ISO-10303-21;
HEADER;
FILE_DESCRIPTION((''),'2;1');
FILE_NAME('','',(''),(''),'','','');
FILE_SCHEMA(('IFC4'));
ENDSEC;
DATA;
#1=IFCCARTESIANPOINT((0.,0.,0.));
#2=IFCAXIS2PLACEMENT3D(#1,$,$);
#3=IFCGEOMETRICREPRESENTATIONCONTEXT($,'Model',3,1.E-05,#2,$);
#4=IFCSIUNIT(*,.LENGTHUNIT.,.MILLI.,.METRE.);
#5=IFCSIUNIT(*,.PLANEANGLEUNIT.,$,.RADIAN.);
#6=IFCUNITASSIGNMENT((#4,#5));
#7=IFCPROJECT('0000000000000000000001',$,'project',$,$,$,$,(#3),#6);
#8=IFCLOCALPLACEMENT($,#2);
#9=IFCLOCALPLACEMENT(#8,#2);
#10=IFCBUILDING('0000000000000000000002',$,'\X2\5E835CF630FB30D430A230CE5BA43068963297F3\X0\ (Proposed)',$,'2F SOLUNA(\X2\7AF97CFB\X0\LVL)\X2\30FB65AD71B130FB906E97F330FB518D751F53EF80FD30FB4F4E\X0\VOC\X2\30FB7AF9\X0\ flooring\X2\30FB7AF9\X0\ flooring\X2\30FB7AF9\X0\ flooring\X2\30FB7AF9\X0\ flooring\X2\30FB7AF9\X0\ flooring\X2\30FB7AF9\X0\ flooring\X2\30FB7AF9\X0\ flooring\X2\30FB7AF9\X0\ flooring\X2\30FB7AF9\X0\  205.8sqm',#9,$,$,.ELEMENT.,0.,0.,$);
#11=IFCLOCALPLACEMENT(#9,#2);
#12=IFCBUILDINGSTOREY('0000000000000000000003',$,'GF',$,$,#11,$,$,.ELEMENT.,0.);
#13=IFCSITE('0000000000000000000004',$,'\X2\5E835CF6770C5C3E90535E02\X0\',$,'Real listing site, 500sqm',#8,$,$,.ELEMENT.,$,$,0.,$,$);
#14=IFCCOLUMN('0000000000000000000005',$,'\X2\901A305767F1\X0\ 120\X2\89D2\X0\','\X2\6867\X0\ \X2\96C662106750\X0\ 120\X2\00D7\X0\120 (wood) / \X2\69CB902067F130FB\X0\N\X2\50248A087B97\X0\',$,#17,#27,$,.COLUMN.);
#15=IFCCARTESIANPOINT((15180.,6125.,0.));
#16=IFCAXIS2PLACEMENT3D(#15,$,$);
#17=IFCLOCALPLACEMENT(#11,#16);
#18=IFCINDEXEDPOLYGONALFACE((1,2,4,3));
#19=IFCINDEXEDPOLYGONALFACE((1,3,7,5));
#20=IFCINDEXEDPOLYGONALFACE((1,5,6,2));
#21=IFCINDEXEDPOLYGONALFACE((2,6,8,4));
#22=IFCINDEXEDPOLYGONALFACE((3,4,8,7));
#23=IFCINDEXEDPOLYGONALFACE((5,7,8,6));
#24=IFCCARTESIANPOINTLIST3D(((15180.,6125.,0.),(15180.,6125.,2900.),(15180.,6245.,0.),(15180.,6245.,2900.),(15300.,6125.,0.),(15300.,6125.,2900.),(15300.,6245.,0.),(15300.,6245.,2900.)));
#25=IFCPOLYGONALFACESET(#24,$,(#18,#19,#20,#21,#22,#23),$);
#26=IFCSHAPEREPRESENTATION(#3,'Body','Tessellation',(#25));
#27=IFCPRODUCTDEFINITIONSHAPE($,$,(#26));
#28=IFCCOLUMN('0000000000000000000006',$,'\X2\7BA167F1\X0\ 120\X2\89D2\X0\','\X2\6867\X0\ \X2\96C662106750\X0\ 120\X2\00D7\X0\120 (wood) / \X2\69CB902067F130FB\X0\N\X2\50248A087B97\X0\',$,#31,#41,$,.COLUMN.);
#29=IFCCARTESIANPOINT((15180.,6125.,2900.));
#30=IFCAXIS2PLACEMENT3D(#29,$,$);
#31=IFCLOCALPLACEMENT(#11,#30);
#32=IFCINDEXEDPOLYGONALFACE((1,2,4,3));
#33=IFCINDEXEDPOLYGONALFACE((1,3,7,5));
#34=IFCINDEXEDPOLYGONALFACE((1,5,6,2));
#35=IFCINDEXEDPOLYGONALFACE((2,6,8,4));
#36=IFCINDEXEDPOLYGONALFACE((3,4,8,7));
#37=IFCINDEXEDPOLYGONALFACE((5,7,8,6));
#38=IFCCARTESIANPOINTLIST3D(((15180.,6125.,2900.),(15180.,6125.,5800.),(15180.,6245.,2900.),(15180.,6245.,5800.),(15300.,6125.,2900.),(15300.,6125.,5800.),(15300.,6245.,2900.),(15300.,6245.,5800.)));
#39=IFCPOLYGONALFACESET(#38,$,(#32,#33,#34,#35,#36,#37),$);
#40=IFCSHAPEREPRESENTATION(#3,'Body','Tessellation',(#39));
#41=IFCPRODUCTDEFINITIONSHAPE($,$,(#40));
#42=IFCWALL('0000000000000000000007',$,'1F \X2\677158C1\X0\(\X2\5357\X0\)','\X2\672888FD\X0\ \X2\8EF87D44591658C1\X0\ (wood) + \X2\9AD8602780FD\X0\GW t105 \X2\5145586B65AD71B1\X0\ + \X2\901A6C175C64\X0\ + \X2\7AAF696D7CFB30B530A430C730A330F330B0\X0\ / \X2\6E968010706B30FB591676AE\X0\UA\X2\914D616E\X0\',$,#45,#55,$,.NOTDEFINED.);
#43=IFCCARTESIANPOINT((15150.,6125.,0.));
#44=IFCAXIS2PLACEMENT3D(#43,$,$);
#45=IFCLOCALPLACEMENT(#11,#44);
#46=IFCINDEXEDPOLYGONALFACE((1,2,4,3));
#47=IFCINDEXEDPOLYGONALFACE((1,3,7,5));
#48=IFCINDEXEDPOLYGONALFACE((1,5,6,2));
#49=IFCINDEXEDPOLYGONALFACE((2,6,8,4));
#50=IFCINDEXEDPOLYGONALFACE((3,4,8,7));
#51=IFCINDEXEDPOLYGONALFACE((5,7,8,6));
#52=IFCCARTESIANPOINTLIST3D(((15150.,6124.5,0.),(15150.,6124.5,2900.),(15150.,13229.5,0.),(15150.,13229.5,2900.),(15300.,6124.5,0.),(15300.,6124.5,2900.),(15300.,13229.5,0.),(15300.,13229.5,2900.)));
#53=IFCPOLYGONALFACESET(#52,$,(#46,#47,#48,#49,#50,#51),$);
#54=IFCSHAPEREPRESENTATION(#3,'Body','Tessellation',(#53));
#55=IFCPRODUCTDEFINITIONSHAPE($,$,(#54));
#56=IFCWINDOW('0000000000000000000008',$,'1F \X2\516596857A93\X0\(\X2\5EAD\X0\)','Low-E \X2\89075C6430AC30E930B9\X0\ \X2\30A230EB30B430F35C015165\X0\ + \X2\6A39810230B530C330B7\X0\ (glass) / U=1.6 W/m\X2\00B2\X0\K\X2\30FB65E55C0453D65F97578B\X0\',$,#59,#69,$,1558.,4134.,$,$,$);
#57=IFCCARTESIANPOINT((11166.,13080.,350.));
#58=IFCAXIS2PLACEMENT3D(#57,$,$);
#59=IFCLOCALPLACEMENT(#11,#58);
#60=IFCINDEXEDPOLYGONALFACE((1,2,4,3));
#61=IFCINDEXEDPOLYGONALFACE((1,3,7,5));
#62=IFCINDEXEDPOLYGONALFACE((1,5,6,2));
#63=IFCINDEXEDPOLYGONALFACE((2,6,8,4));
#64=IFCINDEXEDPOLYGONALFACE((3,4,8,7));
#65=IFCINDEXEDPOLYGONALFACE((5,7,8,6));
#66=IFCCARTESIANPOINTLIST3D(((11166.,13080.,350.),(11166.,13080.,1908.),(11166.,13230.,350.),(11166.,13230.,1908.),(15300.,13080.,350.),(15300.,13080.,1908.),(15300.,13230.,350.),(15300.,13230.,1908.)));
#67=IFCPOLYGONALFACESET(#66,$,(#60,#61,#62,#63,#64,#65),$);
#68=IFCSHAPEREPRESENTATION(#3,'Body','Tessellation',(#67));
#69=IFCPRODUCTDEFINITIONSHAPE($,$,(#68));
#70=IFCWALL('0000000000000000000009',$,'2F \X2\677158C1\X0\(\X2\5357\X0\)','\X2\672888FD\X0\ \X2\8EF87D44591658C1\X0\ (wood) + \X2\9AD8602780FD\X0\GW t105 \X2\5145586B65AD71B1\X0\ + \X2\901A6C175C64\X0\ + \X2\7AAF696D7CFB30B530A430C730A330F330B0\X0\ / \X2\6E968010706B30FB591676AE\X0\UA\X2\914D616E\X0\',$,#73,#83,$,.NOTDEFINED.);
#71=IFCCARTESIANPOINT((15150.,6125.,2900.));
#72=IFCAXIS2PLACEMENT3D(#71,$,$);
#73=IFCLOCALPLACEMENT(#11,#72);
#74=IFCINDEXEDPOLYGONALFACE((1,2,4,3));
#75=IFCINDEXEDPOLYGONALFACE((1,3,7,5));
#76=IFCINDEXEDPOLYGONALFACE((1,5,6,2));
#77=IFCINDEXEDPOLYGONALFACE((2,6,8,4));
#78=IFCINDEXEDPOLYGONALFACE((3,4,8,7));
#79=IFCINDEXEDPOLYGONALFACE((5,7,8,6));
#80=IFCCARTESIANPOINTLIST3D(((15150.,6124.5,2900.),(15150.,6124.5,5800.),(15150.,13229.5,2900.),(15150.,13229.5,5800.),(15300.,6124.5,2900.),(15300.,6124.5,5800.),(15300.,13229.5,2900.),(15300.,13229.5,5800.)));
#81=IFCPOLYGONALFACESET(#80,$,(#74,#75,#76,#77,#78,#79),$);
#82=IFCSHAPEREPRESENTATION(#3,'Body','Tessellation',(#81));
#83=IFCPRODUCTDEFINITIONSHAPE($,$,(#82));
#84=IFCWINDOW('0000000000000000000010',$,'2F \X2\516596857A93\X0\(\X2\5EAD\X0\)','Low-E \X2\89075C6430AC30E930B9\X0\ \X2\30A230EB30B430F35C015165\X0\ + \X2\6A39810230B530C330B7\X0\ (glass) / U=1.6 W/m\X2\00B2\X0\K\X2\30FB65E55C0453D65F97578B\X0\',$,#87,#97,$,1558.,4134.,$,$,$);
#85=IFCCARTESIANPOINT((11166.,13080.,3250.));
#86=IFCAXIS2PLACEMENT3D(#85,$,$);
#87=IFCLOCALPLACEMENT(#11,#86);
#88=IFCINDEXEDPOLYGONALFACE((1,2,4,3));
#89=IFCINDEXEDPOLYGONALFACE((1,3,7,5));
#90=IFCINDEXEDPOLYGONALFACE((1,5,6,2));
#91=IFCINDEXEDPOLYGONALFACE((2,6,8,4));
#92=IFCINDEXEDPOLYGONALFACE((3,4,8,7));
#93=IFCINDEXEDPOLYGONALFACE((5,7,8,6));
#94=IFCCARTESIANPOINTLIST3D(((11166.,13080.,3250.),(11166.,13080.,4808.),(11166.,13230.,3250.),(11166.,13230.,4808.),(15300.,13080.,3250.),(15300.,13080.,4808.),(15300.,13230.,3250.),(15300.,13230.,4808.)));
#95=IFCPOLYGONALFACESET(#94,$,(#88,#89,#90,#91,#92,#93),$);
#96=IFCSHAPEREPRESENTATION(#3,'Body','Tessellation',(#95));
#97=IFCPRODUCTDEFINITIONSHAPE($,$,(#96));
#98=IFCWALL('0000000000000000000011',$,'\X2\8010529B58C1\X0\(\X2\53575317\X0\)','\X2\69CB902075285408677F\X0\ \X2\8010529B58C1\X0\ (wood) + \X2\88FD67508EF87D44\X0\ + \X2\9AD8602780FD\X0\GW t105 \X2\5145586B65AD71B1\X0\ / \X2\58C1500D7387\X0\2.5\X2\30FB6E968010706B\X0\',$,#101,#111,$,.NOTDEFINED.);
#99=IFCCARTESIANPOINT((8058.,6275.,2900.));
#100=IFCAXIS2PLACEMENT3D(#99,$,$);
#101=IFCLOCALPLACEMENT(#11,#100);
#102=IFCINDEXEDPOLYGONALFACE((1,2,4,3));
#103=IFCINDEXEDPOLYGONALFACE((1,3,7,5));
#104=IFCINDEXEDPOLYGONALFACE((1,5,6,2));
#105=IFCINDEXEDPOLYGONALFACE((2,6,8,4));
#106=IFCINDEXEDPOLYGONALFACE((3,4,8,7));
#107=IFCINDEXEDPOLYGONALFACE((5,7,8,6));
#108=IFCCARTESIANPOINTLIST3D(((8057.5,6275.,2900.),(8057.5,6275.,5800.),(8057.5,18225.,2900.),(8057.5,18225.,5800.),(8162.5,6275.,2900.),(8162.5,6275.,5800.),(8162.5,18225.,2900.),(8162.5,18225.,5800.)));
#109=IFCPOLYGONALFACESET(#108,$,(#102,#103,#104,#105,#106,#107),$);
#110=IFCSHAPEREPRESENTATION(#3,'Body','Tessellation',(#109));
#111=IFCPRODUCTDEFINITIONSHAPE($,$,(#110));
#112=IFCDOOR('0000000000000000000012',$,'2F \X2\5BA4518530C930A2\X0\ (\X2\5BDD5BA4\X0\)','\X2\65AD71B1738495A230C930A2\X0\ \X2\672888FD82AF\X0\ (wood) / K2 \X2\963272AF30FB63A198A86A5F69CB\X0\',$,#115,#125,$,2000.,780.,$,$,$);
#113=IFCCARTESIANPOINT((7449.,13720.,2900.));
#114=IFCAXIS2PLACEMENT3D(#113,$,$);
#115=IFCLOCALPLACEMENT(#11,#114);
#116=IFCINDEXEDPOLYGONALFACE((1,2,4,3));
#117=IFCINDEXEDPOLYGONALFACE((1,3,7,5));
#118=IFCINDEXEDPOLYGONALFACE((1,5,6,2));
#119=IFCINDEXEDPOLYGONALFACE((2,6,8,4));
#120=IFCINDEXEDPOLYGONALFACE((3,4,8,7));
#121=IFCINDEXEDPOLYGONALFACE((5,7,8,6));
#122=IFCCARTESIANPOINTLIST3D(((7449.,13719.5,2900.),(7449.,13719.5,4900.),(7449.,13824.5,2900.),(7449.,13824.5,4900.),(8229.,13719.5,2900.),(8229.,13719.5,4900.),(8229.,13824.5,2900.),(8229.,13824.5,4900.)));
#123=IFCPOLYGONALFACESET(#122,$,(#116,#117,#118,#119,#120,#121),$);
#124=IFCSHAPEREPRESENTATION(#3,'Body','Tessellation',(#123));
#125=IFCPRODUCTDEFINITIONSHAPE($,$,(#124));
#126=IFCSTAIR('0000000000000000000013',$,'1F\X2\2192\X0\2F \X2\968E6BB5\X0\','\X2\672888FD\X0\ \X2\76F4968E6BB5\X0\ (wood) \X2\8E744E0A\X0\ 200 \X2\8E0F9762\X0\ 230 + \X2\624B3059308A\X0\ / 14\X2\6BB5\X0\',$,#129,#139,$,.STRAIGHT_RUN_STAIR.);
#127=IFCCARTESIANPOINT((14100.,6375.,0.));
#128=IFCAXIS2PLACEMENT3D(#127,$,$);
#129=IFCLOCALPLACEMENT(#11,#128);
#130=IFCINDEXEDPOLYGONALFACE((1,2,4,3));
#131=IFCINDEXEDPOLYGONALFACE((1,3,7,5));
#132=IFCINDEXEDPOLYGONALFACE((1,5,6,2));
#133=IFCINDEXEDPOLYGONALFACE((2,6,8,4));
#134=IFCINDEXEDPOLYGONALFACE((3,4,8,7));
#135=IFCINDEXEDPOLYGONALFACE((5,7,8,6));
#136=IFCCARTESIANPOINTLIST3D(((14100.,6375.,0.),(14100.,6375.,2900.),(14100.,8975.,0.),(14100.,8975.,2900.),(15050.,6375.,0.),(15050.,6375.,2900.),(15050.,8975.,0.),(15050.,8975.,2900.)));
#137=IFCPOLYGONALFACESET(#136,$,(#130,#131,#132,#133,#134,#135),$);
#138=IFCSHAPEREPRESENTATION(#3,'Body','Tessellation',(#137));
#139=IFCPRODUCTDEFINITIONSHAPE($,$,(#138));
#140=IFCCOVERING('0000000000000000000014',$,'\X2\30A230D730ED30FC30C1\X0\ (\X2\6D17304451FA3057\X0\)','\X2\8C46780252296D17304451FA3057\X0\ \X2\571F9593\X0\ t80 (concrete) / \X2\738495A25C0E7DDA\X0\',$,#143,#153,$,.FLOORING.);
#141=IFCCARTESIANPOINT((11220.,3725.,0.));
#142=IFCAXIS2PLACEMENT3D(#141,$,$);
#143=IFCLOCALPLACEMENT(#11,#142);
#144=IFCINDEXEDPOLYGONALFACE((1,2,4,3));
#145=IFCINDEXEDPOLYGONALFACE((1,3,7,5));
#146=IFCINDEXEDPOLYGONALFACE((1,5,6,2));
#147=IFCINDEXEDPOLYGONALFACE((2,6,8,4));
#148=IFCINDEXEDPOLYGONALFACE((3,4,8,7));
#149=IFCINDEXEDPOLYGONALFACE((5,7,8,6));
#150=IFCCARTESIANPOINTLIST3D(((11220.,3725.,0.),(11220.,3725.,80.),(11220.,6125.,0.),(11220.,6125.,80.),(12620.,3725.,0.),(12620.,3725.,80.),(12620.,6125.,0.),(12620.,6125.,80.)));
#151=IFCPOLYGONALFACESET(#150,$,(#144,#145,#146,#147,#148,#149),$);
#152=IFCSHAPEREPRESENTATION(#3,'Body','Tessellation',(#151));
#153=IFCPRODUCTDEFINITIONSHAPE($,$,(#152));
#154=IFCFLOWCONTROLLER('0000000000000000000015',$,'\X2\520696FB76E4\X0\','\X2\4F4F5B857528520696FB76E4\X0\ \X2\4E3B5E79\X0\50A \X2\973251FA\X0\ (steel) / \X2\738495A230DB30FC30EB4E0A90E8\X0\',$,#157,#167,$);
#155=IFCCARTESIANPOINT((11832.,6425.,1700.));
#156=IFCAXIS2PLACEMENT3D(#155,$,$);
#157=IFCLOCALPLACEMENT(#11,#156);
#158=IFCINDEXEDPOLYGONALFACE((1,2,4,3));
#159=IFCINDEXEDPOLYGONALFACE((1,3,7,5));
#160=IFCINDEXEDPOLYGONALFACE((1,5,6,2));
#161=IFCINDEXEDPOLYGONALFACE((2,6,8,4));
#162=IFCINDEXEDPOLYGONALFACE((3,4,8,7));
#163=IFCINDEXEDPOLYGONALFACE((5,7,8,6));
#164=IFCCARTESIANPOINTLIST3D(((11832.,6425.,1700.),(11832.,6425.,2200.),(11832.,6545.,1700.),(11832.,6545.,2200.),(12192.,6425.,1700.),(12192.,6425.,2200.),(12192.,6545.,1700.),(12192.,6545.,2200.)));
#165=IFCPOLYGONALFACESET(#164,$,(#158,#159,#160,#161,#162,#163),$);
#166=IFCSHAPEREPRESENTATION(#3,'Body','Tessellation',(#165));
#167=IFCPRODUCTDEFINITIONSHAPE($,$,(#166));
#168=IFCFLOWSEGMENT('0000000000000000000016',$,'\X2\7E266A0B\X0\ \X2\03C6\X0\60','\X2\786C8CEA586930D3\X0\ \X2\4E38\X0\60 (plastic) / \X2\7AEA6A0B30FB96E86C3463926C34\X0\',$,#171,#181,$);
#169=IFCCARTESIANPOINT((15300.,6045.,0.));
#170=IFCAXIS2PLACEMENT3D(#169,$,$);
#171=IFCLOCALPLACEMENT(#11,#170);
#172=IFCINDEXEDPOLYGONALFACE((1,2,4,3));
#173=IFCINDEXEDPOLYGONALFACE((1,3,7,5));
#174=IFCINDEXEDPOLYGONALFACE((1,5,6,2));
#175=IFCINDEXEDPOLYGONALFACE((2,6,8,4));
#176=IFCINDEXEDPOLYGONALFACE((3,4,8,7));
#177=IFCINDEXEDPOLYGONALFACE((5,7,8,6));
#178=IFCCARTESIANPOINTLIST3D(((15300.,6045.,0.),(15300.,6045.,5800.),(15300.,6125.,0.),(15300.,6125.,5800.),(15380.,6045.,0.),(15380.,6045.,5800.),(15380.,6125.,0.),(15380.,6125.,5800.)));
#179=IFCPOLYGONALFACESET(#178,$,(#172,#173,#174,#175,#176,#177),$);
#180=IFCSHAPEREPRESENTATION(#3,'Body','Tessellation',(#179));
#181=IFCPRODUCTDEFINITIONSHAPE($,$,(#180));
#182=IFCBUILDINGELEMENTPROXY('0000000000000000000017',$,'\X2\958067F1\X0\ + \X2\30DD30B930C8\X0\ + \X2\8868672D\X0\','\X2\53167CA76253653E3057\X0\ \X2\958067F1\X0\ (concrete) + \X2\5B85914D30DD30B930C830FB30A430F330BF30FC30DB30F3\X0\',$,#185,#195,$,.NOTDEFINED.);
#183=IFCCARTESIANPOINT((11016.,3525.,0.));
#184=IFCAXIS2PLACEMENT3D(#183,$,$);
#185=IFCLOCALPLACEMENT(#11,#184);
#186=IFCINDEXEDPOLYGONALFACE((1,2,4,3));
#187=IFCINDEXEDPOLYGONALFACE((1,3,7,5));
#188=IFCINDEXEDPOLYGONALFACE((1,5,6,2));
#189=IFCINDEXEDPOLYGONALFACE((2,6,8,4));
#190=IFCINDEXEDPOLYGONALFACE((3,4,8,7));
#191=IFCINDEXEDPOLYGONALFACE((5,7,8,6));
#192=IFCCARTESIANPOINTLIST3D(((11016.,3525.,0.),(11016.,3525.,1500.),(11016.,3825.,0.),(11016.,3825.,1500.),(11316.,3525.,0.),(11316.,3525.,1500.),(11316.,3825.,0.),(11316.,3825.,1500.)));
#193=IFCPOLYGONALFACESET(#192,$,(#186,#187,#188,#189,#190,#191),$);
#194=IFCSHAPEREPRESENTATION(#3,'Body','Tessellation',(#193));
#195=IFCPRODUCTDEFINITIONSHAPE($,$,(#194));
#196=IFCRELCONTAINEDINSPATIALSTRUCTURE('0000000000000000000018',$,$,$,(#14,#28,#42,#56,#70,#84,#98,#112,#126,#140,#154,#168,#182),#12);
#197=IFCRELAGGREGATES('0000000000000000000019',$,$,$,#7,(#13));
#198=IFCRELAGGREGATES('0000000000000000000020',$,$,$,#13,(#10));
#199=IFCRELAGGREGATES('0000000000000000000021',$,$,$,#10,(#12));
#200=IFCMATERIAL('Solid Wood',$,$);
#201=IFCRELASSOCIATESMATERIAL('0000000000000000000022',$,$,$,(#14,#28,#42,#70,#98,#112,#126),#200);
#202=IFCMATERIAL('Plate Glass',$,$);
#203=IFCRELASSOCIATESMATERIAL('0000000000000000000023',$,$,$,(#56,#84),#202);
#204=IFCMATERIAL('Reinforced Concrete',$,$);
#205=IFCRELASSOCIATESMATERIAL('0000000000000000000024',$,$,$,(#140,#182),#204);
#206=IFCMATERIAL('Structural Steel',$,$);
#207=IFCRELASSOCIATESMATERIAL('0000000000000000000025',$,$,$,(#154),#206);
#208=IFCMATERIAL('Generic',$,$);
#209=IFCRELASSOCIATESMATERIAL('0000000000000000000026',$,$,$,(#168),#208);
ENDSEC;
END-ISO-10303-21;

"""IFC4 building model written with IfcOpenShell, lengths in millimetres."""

from ifc_helpers import new_model, si_unit, frame, frame_2d, origin, place, context, project, spatial, rectangle, extrude, material, element, fill, save


model = new_model("IFC4")

# Units and contexts
model_context = context("Model", 3, precision=1e-05, world=origin())
ifc_project = project(units=[si_unit("LENGTHUNIT", "METRE", prefix="MILLI"), si_unit("PLANEANGLEUNIT", "RADIAN")], contexts=[model_context])

# Site, building, storey
site_placement = place(None, origin())
site = spatial("IfcSite", under=ifc_project, at=site_placement, Name="広島県尾道市", ObjectType="Real listing site, 500sqm", CompositionType="ELEMENT", RefElevation=0.0)
building_placement = place(site_placement, origin())
building = spatial("IfcBuilding", under=site, at=building_placement, Name="広島・ピアノ室と防音 (Proposed)", ObjectType="2F SOLUNA(竹系LVL)・断熱・遮音・再生可能・低VOC・竹 flooring・竹 flooring・竹 flooring・竹 flooring・竹 flooring・竹 flooring・竹 flooring・竹 flooring・竹  205.8sqm", CompositionType="ELEMENT", ElevationOfRefHeight=0.0, ElevationOfTerrain=0.0)
storey_placement = place(building_placement, origin())
storey = spatial("IfcBuildingStorey", under=building, at=storey_placement, Name="GF", CompositionType="ELEMENT", Elevation=0.0)

# Columns
ifc_material_1 = material(Name="Solid Wood")
column_1_placement = place(storey_placement, frame((15180.0, 6125.0, 0.0)))
element("IfcColumn", 1, at=column_1_placement, inside=storey, material=ifc_material_1, Name="通し柱 120角", Description="桧 集成材 120×120 (wood) / 構造柱・N値計算", PredefinedType="COLUMN", context=model_context, shape_type="SweptSolid", body=[
    extrude(rectangle(XDim=120.0, YDim=120.0, at=frame_2d((60.0, 60.0))), frame((15180.0, 6125.0, 0.0)), (0.0, 0.0, 1.0), 2900.0),
])
column_2_placement = place(storey_placement, frame((15180.0, 6125.0, 2900.0)))
element("IfcColumn", 2, at=column_2_placement, inside=storey, material=ifc_material_1, Name="管柱 120角", Description="桧 集成材 120×120 (wood) / 構造柱・N値計算", PredefinedType="COLUMN", context=model_context, shape_type="SweptSolid", body=[
    extrude(rectangle(XDim=120.0, YDim=120.0, at=frame_2d((60.0, 60.0))), frame((15180.0, 6125.0, 2900.0)), (0.0, 0.0, 1.0), 2900.0),
])

# Wall, opening, window
wall_1_placement = place(storey_placement, frame((15150.0, 6125.0, 0.0)))
wall_1 = element("IfcWall", 3, at=wall_1_placement, inside=storey, material=ifc_material_1, Name="1F 東壁(南)", Description="木製 軸組外壁 (wood) + 高性能GW t105 充填断熱 + 通気層 + 窯業系サイディング / 準耐火・外皮UA配慮", PredefinedType="NOTDEFINED", context=model_context, shape_type="SweptSolid", body=[
    extrude(rectangle(XDim=150.0, YDim=7105.0, at=frame_2d((75.0, 3552.0))), frame((15150.0, 6125.0, 0.0)), (0.0, 0.0, 1.0), 2900.0),
])
opening_1_placement = place(storey_placement, frame((11166.0, 13080.0, 350.0)))
opening_1 = element("IfcOpeningElement", 4, at=opening_1_placement, cuts=wall_1, PredefinedType="NOTDEFINED", context=model_context, shape_type="SweptSolid", body=[
    extrude(rectangle(XDim=4134.0, YDim=150.0, at=frame_2d((2067.0, 75.0))), frame((11166.0, 13080.0, 350.0)), (0.0, 0.0, 1.0), 1558.0),
])
ifc_material_2 = material(Name="Plate Glass")
window_1_placement = place(storey_placement, frame((11166.0, 13080.0, 350.0)))
window_1 = element("IfcWindow", 5, at=window_1_placement, inside=storey, material=ifc_material_2, Name="1F 入隅窓(庭)", Description="Low-E 複層ガラス アルゴン封入 + 樹脂サッシ (glass) / U=1.6 W/m²K・日射取得型", OverallHeight=1558.0, OverallWidth=4134.0, context=model_context, shape_type="SweptSolid", body=[
    extrude(rectangle(XDim=4134.0, YDim=150.0, at=frame_2d((2067.0, 75.0))), frame((11166.0, 13080.0, 350.0)), (0.0, 0.0, 1.0), 1558.0),
])
fill(opening_1, window_1)

# Wall, opening, window
wall_2_placement = place(storey_placement, frame((15150.0, 6125.0, 2900.0)))
wall_2 = element("IfcWall", 6, at=wall_2_placement, inside=storey, material=ifc_material_1, Name="2F 東壁(南)", Description="木製 軸組外壁 (wood) + 高性能GW t105 充填断熱 + 通気層 + 窯業系サイディング / 準耐火・外皮UA配慮", PredefinedType="NOTDEFINED", context=model_context, shape_type="SweptSolid", body=[
    extrude(rectangle(XDim=150.0, YDim=7105.0, at=frame_2d((75.0, 3552.0))), frame((15150.0, 6125.0, 2900.0)), (0.0, 0.0, 1.0), 2900.0),
])
opening_2_placement = place(storey_placement, frame((11166.0, 13080.0, 3250.0)))
opening_2 = element("IfcOpeningElement", 7, at=opening_2_placement, cuts=wall_2, PredefinedType="NOTDEFINED", context=model_context, shape_type="SweptSolid", body=[
    extrude(rectangle(XDim=4134.0, YDim=150.0, at=frame_2d((2067.0, 75.0))), frame((11166.0, 13080.0, 3250.0)), (0.0, 0.0, 1.0), 1558.0),
])
window_2_placement = place(storey_placement, frame((11166.0, 13080.0, 3250.0)))
window_2 = element("IfcWindow", 8, at=window_2_placement, inside=storey, material=ifc_material_2, Name="2F 入隅窓(庭)", Description="Low-E 複層ガラス アルゴン封入 + 樹脂サッシ (glass) / U=1.6 W/m²K・日射取得型", OverallHeight=1558.0, OverallWidth=4134.0, context=model_context, shape_type="SweptSolid", body=[
    extrude(rectangle(XDim=4134.0, YDim=150.0, at=frame_2d((2067.0, 75.0))), frame((11166.0, 13080.0, 3250.0)), (0.0, 0.0, 1.0), 1558.0),
])
fill(opening_2, window_2)

# Wall, opening, door
wall_3_placement = place(storey_placement, frame((8058.0, 6275.0, 2900.0)))
wall_3 = element("IfcWall", 9, at=wall_3_placement, inside=storey, material=ifc_material_1, Name="耐力壁(南北)", Description="構造用合板 耐力壁 (wood) + 製材軸組 + 高性能GW t105 充填断熱 / 壁倍率2.5・準耐火", PredefinedType="NOTDEFINED", context=model_context, shape_type="SweptSolid", body=[
    extrude(rectangle(XDim=105.0, YDim=11950.0, at=frame_2d((52.0, 5975.0))), frame((8058.0, 6275.0, 2900.0)), (0.0, 0.0, 1.0), 2900.0),
])
opening_3_placement = place(storey_placement, frame((7449.0, 13720.0, 2900.0)))
opening_3 = element("IfcOpeningElement", 10, at=opening_3_placement, cuts=wall_3, PredefinedType="NOTDEFINED", context=model_context, shape_type="SweptSolid", body=[
    extrude(rectangle(XDim=780.0, YDim=105.0, at=frame_2d((390.0, 52.0))), frame((7449.0, 13720.0, 2900.0)), (0.0, 0.0, 1.0), 2000.0),
])
door_1_placement = place(storey_placement, frame((7449.0, 13720.0, 2900.0)))
door_1 = element("IfcDoor", 11, at=door_1_placement, inside=storey, material=ifc_material_1, Name="2F 室内ドア (寝室)", Description="断熱玄関ドア 木製芯 (wood) / K2 防犯・採風機構", OverallHeight=2000.0, OverallWidth=780.0, context=model_context, shape_type="SweptSolid", body=[
    extrude(rectangle(XDim=780.0, YDim=105.0, at=frame_2d((390.0, 52.0))), frame((7449.0, 13720.0, 2900.0)), (0.0, 0.0, 1.0), 2000.0),
])
fill(opening_3, door_1)

# Stair
stair_placement = place(storey_placement, frame((14100.0, 6375.0, 0.0)))
element("IfcStair", 12, at=stair_placement, inside=storey, material=ifc_material_1, Name="1F→2F 階段", Description="木製 直階段 (wood) 蹴上 200 踏面 230 + 手すり / 14段", PredefinedType="STRAIGHT_RUN_STAIR", context=model_context, shape_type="SweptSolid", body=[
    extrude(rectangle(XDim=950.0, YDim=2600.0, at=frame_2d((475.0, 1300.0))), frame((14100.0, 6375.0, 0.0)), (0.0, 0.0, 1.0), 2900.0),
])

# Covering
ifc_material_3 = material(Name="Reinforced Concrete")
covering_placement = place(storey_placement, frame((11220.0, 3725.0, 0.0)))
element("IfcCovering", 13, at=covering_placement, inside=storey, material=ifc_material_3, Name="アプローチ (洗い出し)", Description="豆砂利洗い出し 土間 t80 (concrete) / 玄関導線", PredefinedType="FLOORING", context=model_context, shape_type="SweptSolid", body=[
    extrude(rectangle(XDim=1400.0, YDim=2400.0, at=frame_2d((700.0, 1200.0))), frame((11220.0, 3725.0, 0.0)), (0.0, 0.0, 1.0), 80.0),
])

# Flow controller
ifc_material_4 = material(Name="Structural Steel")
flow_controller_placement = place(storey_placement, frame((11832.0, 6425.0, 1700.0)))
element("IfcFlowController", 14, at=flow_controller_placement, inside=storey, material=ifc_material_4, Name="分電盤", Description="住宅用分電盤 主幹50A 露出 (steel) / 玄関ホール上部", context=model_context, shape_type="SweptSolid", body=[
    extrude(rectangle(XDim=360.0, YDim=120.0, at=frame_2d((180.0, 60.0))), frame((11832.0, 6425.0, 1700.0)), (0.0, 0.0, 1.0), 500.0),
])

# Flow segment
ifc_material_5 = material(Name="Generic")
flow_segment_placement = place(storey_placement, frame((15300.0, 6045.0, 0.0)))
element("IfcFlowSegment", 15, at=flow_segment_placement, inside=storey, material=ifc_material_5, Name="縦樋 φ60", Description="硬質塩ビ 丸60 (plastic) / 竪樋・雨水排水", context=model_context, shape_type="SweptSolid", body=[
    extrude(rectangle(XDim=80.0, YDim=80.0, at=frame_2d((40.0, 40.0))), frame((15300.0, 6045.0, 0.0)), (0.0, 0.0, 1.0), 5800.0),
])

# Building element proxy
proxy_placement = place(storey_placement, frame((11016.0, 3525.0, 0.0)))
element("IfcBuildingElementProxy", 16, at=proxy_placement, inside=storey, material=ifc_material_3, Name="門柱 + ポスト + 表札", Description="化粧打放し 門柱 (concrete) + 宅配ポスト・インターホン", PredefinedType="NOTDEFINED", context=model_context, shape_type="SweptSolid", body=[
    extrude(rectangle(XDim=300.0, YDim=300.0, at=frame_2d((150.0, 150.0))), frame((11016.0, 3525.0, 0.0)), (0.0, 0.0, 1.0), 1500.0),
])

save(model, "model.ifc")
